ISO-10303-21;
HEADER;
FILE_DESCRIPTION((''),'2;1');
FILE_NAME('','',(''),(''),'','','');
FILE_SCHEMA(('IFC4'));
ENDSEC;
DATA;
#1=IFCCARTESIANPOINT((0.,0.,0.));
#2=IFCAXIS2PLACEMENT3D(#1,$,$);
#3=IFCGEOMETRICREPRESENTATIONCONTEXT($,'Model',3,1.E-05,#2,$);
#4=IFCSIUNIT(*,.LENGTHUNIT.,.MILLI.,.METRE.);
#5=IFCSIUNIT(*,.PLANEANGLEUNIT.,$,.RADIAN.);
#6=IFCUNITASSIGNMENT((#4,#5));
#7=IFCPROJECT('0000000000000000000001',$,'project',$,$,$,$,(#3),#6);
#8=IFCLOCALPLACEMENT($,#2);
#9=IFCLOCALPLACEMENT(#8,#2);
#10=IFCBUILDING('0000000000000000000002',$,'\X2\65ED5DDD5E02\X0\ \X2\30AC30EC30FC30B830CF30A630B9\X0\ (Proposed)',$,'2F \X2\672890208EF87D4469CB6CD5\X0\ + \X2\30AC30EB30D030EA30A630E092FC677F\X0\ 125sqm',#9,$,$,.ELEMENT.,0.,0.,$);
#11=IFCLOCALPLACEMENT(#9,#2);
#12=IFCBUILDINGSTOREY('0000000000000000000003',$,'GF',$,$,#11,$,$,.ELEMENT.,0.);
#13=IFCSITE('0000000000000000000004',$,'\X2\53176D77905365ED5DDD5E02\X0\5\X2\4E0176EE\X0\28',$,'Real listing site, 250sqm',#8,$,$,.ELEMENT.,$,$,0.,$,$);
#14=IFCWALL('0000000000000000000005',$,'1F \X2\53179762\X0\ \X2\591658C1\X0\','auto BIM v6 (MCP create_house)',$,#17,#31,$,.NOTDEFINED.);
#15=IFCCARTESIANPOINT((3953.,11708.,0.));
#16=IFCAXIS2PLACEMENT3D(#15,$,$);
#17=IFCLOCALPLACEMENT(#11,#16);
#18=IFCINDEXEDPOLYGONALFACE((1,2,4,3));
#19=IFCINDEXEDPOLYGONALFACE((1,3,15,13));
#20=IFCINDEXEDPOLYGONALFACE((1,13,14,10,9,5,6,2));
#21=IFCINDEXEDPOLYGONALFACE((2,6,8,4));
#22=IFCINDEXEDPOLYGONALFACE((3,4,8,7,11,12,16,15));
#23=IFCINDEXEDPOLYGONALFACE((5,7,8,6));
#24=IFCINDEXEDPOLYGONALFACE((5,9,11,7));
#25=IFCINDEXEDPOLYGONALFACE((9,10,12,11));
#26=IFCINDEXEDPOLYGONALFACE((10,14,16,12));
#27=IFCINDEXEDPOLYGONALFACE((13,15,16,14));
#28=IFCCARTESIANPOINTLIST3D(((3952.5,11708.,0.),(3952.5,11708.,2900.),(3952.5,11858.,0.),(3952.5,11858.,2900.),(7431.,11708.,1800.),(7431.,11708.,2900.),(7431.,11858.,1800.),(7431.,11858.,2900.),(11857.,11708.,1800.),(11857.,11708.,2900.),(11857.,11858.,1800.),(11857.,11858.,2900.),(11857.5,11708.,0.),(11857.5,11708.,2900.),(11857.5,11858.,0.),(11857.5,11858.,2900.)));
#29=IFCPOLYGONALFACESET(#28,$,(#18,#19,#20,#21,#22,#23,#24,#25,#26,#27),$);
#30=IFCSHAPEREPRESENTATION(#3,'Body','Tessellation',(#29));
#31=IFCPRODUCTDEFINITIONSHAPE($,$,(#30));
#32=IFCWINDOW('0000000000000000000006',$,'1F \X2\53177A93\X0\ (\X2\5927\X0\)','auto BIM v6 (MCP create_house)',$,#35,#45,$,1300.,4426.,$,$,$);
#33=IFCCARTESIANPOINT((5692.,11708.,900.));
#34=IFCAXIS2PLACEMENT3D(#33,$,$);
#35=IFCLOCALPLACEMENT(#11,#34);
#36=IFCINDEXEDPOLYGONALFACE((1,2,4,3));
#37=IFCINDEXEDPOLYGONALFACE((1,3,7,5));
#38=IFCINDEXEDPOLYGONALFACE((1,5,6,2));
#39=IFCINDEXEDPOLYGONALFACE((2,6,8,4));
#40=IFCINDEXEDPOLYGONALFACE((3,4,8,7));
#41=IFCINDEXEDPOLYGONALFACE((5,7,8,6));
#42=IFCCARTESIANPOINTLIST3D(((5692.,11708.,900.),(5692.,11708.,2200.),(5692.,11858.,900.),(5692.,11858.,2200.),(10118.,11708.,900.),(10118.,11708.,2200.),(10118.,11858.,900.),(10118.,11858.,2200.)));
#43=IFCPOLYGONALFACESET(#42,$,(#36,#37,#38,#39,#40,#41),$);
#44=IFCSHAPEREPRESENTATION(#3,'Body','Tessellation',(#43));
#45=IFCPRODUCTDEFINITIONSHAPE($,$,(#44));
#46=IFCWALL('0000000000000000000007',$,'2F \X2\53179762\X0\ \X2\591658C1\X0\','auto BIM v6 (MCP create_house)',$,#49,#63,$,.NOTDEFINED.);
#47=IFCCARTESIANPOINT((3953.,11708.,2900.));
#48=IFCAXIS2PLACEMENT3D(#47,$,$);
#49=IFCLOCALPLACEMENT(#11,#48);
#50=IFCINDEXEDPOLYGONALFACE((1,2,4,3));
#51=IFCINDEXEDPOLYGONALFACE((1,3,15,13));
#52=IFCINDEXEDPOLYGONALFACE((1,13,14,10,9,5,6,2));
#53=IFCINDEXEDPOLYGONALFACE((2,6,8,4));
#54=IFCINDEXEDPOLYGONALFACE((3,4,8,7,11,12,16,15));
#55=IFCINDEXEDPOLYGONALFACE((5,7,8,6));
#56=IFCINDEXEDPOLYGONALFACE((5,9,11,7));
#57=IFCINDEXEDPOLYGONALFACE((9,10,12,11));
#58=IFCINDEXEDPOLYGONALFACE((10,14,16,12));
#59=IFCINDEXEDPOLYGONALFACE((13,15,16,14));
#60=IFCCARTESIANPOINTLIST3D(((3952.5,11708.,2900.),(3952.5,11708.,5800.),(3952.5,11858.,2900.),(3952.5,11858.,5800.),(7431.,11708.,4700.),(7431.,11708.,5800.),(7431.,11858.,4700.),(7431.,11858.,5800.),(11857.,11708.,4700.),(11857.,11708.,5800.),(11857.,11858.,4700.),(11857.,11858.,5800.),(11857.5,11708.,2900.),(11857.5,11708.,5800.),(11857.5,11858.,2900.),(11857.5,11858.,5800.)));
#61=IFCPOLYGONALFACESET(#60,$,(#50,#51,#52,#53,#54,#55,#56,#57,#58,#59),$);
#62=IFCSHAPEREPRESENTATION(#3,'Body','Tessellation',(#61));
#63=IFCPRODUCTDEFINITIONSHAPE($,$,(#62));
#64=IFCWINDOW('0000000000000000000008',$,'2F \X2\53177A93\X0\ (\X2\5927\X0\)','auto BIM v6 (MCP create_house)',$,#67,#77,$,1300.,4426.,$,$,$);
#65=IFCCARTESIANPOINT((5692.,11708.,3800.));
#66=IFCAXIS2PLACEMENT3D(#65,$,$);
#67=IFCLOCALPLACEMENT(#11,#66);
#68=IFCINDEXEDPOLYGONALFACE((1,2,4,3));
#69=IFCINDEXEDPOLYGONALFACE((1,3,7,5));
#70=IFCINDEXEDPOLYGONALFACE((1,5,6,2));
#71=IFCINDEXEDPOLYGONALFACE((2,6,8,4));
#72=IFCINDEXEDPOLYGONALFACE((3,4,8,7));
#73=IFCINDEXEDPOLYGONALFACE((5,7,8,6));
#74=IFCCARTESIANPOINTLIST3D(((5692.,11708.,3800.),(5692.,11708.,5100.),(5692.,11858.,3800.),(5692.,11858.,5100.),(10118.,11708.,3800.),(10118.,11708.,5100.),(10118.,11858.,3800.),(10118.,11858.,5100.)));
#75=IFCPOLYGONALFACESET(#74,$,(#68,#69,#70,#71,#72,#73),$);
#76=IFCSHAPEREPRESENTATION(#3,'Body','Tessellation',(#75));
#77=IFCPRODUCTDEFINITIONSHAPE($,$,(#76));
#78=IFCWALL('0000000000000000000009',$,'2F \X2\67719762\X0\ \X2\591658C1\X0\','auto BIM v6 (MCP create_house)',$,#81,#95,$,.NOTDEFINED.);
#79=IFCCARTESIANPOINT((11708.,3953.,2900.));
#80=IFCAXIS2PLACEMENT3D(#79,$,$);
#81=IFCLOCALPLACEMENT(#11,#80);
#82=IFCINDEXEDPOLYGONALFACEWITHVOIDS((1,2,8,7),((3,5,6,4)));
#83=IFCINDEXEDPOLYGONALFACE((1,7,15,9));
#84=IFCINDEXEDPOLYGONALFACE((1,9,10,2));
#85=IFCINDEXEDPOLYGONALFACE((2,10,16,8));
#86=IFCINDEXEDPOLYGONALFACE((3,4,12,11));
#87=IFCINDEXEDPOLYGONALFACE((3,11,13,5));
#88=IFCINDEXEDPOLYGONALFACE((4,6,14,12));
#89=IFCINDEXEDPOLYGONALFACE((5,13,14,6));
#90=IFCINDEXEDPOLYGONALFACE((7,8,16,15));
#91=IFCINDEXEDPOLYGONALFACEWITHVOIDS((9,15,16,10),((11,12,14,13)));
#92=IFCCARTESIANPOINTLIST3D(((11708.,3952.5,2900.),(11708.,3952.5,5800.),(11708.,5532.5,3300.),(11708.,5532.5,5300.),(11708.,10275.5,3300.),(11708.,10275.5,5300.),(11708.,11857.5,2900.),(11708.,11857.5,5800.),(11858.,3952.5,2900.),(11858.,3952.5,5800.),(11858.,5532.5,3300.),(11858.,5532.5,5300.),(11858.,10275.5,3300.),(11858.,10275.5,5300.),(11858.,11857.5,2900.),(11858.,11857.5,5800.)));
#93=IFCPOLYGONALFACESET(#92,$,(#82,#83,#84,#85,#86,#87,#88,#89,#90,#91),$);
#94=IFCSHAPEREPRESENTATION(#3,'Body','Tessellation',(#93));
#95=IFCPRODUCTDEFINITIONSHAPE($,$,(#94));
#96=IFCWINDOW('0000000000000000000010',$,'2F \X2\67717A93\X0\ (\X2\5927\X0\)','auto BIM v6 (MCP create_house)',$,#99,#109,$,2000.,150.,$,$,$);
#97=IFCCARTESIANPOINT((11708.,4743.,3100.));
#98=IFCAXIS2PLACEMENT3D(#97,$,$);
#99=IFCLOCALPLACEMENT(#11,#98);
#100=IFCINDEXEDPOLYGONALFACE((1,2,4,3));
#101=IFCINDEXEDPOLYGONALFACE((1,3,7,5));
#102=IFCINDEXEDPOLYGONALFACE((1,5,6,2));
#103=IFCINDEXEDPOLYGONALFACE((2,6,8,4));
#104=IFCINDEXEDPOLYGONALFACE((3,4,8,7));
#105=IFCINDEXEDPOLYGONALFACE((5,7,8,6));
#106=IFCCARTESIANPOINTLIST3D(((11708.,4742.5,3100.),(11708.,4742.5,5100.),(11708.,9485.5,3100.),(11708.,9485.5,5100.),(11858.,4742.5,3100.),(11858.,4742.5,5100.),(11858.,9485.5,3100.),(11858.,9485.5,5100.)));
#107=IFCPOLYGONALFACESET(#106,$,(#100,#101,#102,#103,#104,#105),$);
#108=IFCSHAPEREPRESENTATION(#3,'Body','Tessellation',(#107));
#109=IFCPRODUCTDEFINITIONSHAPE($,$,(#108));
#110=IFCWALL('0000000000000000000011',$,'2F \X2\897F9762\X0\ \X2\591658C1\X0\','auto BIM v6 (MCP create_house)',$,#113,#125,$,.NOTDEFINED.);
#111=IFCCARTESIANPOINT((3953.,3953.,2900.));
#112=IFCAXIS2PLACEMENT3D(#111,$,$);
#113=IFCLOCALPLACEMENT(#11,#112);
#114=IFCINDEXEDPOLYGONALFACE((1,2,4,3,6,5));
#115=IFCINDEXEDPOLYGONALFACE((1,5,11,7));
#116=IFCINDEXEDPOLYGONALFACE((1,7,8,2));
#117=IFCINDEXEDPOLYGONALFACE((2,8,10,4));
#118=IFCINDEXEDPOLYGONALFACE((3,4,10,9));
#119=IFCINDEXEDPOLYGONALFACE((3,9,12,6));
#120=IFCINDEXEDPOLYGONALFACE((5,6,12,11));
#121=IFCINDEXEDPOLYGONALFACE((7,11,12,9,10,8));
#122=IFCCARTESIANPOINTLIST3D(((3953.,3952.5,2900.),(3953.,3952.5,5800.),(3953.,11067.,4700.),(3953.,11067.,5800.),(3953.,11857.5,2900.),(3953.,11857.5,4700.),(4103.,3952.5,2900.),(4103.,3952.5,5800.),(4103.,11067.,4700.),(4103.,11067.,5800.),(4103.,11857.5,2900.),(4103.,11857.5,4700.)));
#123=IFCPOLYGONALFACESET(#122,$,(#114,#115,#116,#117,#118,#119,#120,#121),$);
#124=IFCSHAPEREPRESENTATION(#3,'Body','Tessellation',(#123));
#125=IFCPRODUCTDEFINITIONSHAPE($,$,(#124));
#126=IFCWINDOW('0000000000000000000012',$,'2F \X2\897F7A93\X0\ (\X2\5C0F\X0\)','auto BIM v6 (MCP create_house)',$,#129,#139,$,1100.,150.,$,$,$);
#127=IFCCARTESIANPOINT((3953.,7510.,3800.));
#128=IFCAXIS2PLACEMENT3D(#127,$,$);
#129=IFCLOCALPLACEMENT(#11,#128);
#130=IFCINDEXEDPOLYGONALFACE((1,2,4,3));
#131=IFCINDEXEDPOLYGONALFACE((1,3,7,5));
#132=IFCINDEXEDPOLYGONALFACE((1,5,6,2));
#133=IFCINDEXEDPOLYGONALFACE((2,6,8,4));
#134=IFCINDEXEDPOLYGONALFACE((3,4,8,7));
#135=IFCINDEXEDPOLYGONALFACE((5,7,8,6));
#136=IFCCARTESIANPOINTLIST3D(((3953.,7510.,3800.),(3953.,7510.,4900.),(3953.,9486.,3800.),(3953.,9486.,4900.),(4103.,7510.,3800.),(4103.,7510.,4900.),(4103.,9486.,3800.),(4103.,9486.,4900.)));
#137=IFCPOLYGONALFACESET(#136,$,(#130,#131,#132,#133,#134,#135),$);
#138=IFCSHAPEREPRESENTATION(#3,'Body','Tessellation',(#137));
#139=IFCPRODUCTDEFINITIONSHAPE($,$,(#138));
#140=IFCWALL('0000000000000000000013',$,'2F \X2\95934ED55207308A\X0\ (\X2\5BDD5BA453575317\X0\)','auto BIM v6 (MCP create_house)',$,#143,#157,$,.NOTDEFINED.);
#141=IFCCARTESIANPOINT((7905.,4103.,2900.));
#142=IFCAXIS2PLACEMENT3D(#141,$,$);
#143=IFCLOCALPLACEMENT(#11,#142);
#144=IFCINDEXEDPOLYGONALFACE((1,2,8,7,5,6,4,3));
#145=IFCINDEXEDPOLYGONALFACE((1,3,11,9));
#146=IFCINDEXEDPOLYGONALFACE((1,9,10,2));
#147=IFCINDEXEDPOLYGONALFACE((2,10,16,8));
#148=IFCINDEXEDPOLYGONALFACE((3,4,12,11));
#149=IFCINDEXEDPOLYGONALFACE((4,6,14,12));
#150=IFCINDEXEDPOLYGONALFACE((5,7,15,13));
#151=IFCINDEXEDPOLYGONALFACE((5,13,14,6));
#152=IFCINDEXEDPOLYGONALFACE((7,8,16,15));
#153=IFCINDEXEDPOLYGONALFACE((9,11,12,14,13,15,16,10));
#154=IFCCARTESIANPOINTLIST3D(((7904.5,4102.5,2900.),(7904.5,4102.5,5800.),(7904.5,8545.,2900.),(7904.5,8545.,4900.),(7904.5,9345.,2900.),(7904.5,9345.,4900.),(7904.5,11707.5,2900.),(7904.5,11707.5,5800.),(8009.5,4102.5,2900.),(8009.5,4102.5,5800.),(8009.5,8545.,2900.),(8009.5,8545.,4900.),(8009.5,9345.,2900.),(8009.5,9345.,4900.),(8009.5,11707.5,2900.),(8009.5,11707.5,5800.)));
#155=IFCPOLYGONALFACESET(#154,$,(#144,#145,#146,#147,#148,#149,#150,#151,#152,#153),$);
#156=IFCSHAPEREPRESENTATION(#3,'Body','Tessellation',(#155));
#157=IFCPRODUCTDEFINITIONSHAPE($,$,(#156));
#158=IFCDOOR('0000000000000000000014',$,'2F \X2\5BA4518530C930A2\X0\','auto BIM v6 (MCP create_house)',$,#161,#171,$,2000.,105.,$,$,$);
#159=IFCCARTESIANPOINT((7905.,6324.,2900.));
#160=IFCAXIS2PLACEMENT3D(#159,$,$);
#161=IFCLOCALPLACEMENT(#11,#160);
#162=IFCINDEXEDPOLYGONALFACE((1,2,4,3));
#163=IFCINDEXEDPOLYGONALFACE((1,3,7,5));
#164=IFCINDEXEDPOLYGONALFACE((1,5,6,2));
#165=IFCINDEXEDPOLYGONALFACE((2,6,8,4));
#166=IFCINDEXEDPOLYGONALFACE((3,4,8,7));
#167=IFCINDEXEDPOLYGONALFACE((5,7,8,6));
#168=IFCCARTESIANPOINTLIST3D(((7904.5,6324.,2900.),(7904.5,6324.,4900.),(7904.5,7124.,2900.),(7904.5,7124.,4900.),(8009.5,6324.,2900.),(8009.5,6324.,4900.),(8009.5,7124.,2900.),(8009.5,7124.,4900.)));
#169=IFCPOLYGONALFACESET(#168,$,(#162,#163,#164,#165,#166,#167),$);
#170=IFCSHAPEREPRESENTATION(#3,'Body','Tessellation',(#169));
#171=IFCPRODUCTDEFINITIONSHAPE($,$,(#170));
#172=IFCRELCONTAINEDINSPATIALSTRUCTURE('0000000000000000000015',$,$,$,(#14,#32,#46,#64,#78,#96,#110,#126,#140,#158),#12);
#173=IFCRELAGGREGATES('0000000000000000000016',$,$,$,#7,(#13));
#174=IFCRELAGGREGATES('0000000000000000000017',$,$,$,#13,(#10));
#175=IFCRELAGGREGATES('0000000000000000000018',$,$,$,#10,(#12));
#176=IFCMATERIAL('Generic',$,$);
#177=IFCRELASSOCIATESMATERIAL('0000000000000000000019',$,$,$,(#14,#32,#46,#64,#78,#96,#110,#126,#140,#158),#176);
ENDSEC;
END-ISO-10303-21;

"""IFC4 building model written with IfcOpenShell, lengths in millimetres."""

from ifc_helpers import new_model, si_unit, frame, frame_2d, origin, place, context, project, spatial, rectangle, extrude, material, element, fill, save


model = new_model("IFC4")

# Units and contexts
model_context = context("Model", 3, precision=1e-05, world=origin())
ifc_project = project(units=[si_unit("LENGTHUNIT", "METRE", prefix="MILLI"), si_unit("PLANEANGLEUNIT", "RADIAN")], contexts=[model_context])

# Site, building, storey
site_placement = place(None, origin())
site = spatial("IfcSite", under=ifc_project, at=site_placement, Name="北海道旭川市5丁目28", ObjectType="Real listing site, 250sqm", CompositionType="ELEMENT", RefElevation=0.0)
building_placement = place(site_placement, origin())
building = spatial("IfcBuilding", under=site, at=building_placement, Name="旭川市 ガレージハウス (Proposed)", ObjectType="2F 木造軸組構法 + ガルバリウム鋼板 125sqm", CompositionType="ELEMENT", ElevationOfRefHeight=0.0, ElevationOfTerrain=0.0)
storey_placement = place(building_placement, origin())
storey = spatial("IfcBuildingStorey", under=building, at=storey_placement, Name="GF", CompositionType="ELEMENT", Elevation=0.0)

# Wall, opening, window
ifc_material = material(Name="Generic")
wall_1_placement = place(storey_placement, frame((3953.0, 11708.0, 0.0)))
wall_1 = element("IfcWall", 1, at=wall_1_placement, inside=storey, material=ifc_material, Name="1F 北面 外壁", Description="auto BIM v6 (MCP create_house)", PredefinedType="NOTDEFINED", context=model_context, shape_type="SweptSolid", body=[
    extrude(rectangle(XDim=7905.0, YDim=150.0, at=frame_2d((3952.0, 75.0))), frame((3953.0, 11708.0, 0.0)), (0.0, 0.0, 1.0), 2900.0),
])
opening_1_placement = place(storey_placement, frame((5692.0, 11708.0, 900.0)))
opening_1 = element("IfcOpeningElement", 2, at=opening_1_placement, cuts=wall_1, PredefinedType="NOTDEFINED", context=model_context, shape_type="SweptSolid", body=[
    extrude(rectangle(XDim=4426.0, YDim=150.0, at=frame_2d((2213.0, 75.0))), frame((5692.0, 11708.0, 900.0)), (0.0, 0.0, 1.0), 1300.0),
])
window_1_placement = place(storey_placement, frame((5692.0, 11708.0, 900.0)))
window_1 = element("IfcWindow", 3, at=window_1_placement, inside=storey, material=ifc_material, Name="1F 北窓 (大)", Description="auto BIM v6 (MCP create_house)", OverallHeight=1300.0, OverallWidth=4426.0, context=model_context, shape_type="SweptSolid", body=[
    extrude(rectangle(XDim=4426.0, YDim=150.0, at=frame_2d((2213.0, 75.0))), frame((5692.0, 11708.0, 900.0)), (0.0, 0.0, 1.0), 1300.0),
])
fill(opening_1, window_1)

# Walls, openings, windows
wall_2_placement = place(storey_placement, frame((3953.0, 11708.0, 2900.0)))
wall_2 = element("IfcWall", 4, at=wall_2_placement, inside=storey, material=ifc_material, Name="2F 北面 外壁", Description="auto BIM v6 (MCP create_house)", PredefinedType="NOTDEFINED", context=model_context, shape_type="SweptSolid", body=[
    extrude(rectangle(XDim=7905.0, YDim=150.0, at=frame_2d((3952.0, 75.0))), frame((3953.0, 11708.0, 2900.0)), (0.0, 0.0, 1.0), 2900.0),
])
opening_2_placement = place(storey_placement, frame((5692.0, 11708.0, 3800.0)))
opening_2 = element("IfcOpeningElement", 5, at=opening_2_placement, cuts=wall_2, PredefinedType="NOTDEFINED", context=model_context, shape_type="SweptSolid", body=[
    extrude(rectangle(XDim=4426.0, YDim=150.0, at=frame_2d((2213.0, 75.0))), frame((5692.0, 11708.0, 3800.0)), (0.0, 0.0, 1.0), 1300.0),
])
window_2_placement = place(storey_placement, frame((5692.0, 11708.0, 3800.0)))
window_2 = element("IfcWindow", 6, at=window_2_placement, inside=storey, material=ifc_material, Name="2F 北窓 (大)", Description="auto BIM v6 (MCP create_house)", OverallHeight=1300.0, OverallWidth=4426.0, context=model_context, shape_type="SweptSolid", body=[
    extrude(rectangle(XDim=4426.0, YDim=150.0, at=frame_2d((2213.0, 75.0))), frame((5692.0, 11708.0, 3800.0)), (0.0, 0.0, 1.0), 1300.0),
])
fill(opening_2, window_2)
wall_3_placement = place(storey_placement, frame((11708.0, 3953.0, 2900.0)))
wall_3 = element("IfcWall", 7, at=wall_3_placement, inside=storey, material=ifc_material, Name="2F 東面 外壁", Description="auto BIM v6 (MCP create_house)", PredefinedType="NOTDEFINED", context=model_context, shape_type="SweptSolid", body=[
    extrude(rectangle(XDim=150.0, YDim=7905.0, at=frame_2d((75.0, 3952.0))), frame((11708.0, 3953.0, 2900.0)), (0.0, 0.0, 1.0), 2900.0),
])
opening_3_placement = place(storey_placement, frame((11708.0, 4743.0, 3100.0)))
opening_3 = element("IfcOpeningElement", 8, at=opening_3_placement, cuts=wall_3, PredefinedType="NOTDEFINED", context=model_context, shape_type="SweptSolid", body=[
    extrude(rectangle(XDim=150.0, YDim=4743.0, at=frame_2d((75.0, 2371.0))), frame((11708.0, 4743.0, 3100.0)), (0.0, 0.0, 1.0), 2000.0),
])
window_3_placement = place(storey_placement, frame((11708.0, 4743.0, 3100.0)))
window_3 = element("IfcWindow", 9, at=window_3_placement, inside=storey, material=ifc_material, Name="2F 東窓 (大)", Description="auto BIM v6 (MCP create_house)", OverallHeight=2000.0, OverallWidth=150.0, context=model_context, shape_type="SweptSolid", body=[
    extrude(rectangle(XDim=150.0, YDim=4743.0, at=frame_2d((75.0, 2371.0))), frame((11708.0, 4743.0, 3100.0)), (0.0, 0.0, 1.0), 2000.0),
])
fill(opening_3, window_3)
wall_4_placement = place(storey_placement, frame((3953.0, 3953.0, 2900.0)))
wall_4 = element("IfcWall", 10, at=wall_4_placement, inside=storey, material=ifc_material, Name="2F 西面 外壁", Description="auto BIM v6 (MCP create_house)", PredefinedType="NOTDEFINED", context=model_context, shape_type="SweptSolid", body=[
    extrude(rectangle(XDim=150.0, YDim=7905.0, at=frame_2d((75.0, 3952.0))), frame((3953.0, 3953.0, 2900.0)), (0.0, 0.0, 1.0), 2900.0),
])
opening_4_placement = place(storey_placement, frame((3953.0, 7510.0, 3800.0)))
opening_4 = element("IfcOpeningElement", 11, at=opening_4_placement, cuts=wall_4, PredefinedType="NOTDEFINED", context=model_context, shape_type="SweptSolid", body=[
    extrude(rectangle(XDim=150.0, YDim=1976.0, at=frame_2d((75.0, 988.0))), frame((3953.0, 7510.0, 3800.0)), (0.0, 0.0, 1.0), 1100.0),
])
window_4_placement = place(storey_placement, frame((3953.0, 7510.0, 3800.0)))
window_4 = element("IfcWindow", 12, at=window_4_placement, inside=storey, material=ifc_material, Name="2F 西窓 (小)", Description="auto BIM v6 (MCP create_house)", OverallHeight=1100.0, OverallWidth=150.0, context=model_context, shape_type="SweptSolid", body=[
    extrude(rectangle(XDim=150.0, YDim=1976.0, at=frame_2d((75.0, 988.0))), frame((3953.0, 7510.0, 3800.0)), (0.0, 0.0, 1.0), 1100.0),
])
fill(opening_4, window_4)

# Wall, opening, door
wall_5_placement = place(storey_placement, frame((7905.0, 4103.0, 2900.0)))
wall_5 = element("IfcWall", 13, at=wall_5_placement, inside=storey, material=ifc_material, Name="2F 間仕切り (寝室南北)", Description="auto BIM v6 (MCP create_house)", PredefinedType="NOTDEFINED", context=model_context, shape_type="SweptSolid", body=[
    extrude(rectangle(XDim=105.0, YDim=7605.0, at=frame_2d((52.0, 3802.0))), frame((7905.0, 4103.0, 2900.0)), (0.0, 0.0, 1.0), 2900.0),
])
opening_5_placement = place(storey_placement, frame((7905.0, 6324.0, 2900.0)))
opening_5 = element("IfcOpeningElement", 14, at=opening_5_placement, cuts=wall_5, PredefinedType="NOTDEFINED", context=model_context, shape_type="SweptSolid", body=[
    extrude(rectangle(XDim=105.0, YDim=800.0, at=frame_2d((52.0, 400.0))), frame((7905.0, 6324.0, 2900.0)), (0.0, 0.0, 1.0), 2000.0),
])
door_placement = place(storey_placement, frame((7905.0, 6324.0, 2900.0)))
door = element("IfcDoor", 15, at=door_placement, inside=storey, material=ifc_material, Name="2F 室内ドア", Description="auto BIM v6 (MCP create_house)", OverallHeight=2000.0, OverallWidth=105.0, context=model_context, shape_type="SweptSolid", body=[
    extrude(rectangle(XDim=105.0, YDim=800.0, at=frame_2d((52.0, 400.0))), frame((7905.0, 6324.0, 2900.0)), (0.0, 0.0, 1.0), 2000.0),
])
fill(opening_5, door)

save(model, "model.ifc")
